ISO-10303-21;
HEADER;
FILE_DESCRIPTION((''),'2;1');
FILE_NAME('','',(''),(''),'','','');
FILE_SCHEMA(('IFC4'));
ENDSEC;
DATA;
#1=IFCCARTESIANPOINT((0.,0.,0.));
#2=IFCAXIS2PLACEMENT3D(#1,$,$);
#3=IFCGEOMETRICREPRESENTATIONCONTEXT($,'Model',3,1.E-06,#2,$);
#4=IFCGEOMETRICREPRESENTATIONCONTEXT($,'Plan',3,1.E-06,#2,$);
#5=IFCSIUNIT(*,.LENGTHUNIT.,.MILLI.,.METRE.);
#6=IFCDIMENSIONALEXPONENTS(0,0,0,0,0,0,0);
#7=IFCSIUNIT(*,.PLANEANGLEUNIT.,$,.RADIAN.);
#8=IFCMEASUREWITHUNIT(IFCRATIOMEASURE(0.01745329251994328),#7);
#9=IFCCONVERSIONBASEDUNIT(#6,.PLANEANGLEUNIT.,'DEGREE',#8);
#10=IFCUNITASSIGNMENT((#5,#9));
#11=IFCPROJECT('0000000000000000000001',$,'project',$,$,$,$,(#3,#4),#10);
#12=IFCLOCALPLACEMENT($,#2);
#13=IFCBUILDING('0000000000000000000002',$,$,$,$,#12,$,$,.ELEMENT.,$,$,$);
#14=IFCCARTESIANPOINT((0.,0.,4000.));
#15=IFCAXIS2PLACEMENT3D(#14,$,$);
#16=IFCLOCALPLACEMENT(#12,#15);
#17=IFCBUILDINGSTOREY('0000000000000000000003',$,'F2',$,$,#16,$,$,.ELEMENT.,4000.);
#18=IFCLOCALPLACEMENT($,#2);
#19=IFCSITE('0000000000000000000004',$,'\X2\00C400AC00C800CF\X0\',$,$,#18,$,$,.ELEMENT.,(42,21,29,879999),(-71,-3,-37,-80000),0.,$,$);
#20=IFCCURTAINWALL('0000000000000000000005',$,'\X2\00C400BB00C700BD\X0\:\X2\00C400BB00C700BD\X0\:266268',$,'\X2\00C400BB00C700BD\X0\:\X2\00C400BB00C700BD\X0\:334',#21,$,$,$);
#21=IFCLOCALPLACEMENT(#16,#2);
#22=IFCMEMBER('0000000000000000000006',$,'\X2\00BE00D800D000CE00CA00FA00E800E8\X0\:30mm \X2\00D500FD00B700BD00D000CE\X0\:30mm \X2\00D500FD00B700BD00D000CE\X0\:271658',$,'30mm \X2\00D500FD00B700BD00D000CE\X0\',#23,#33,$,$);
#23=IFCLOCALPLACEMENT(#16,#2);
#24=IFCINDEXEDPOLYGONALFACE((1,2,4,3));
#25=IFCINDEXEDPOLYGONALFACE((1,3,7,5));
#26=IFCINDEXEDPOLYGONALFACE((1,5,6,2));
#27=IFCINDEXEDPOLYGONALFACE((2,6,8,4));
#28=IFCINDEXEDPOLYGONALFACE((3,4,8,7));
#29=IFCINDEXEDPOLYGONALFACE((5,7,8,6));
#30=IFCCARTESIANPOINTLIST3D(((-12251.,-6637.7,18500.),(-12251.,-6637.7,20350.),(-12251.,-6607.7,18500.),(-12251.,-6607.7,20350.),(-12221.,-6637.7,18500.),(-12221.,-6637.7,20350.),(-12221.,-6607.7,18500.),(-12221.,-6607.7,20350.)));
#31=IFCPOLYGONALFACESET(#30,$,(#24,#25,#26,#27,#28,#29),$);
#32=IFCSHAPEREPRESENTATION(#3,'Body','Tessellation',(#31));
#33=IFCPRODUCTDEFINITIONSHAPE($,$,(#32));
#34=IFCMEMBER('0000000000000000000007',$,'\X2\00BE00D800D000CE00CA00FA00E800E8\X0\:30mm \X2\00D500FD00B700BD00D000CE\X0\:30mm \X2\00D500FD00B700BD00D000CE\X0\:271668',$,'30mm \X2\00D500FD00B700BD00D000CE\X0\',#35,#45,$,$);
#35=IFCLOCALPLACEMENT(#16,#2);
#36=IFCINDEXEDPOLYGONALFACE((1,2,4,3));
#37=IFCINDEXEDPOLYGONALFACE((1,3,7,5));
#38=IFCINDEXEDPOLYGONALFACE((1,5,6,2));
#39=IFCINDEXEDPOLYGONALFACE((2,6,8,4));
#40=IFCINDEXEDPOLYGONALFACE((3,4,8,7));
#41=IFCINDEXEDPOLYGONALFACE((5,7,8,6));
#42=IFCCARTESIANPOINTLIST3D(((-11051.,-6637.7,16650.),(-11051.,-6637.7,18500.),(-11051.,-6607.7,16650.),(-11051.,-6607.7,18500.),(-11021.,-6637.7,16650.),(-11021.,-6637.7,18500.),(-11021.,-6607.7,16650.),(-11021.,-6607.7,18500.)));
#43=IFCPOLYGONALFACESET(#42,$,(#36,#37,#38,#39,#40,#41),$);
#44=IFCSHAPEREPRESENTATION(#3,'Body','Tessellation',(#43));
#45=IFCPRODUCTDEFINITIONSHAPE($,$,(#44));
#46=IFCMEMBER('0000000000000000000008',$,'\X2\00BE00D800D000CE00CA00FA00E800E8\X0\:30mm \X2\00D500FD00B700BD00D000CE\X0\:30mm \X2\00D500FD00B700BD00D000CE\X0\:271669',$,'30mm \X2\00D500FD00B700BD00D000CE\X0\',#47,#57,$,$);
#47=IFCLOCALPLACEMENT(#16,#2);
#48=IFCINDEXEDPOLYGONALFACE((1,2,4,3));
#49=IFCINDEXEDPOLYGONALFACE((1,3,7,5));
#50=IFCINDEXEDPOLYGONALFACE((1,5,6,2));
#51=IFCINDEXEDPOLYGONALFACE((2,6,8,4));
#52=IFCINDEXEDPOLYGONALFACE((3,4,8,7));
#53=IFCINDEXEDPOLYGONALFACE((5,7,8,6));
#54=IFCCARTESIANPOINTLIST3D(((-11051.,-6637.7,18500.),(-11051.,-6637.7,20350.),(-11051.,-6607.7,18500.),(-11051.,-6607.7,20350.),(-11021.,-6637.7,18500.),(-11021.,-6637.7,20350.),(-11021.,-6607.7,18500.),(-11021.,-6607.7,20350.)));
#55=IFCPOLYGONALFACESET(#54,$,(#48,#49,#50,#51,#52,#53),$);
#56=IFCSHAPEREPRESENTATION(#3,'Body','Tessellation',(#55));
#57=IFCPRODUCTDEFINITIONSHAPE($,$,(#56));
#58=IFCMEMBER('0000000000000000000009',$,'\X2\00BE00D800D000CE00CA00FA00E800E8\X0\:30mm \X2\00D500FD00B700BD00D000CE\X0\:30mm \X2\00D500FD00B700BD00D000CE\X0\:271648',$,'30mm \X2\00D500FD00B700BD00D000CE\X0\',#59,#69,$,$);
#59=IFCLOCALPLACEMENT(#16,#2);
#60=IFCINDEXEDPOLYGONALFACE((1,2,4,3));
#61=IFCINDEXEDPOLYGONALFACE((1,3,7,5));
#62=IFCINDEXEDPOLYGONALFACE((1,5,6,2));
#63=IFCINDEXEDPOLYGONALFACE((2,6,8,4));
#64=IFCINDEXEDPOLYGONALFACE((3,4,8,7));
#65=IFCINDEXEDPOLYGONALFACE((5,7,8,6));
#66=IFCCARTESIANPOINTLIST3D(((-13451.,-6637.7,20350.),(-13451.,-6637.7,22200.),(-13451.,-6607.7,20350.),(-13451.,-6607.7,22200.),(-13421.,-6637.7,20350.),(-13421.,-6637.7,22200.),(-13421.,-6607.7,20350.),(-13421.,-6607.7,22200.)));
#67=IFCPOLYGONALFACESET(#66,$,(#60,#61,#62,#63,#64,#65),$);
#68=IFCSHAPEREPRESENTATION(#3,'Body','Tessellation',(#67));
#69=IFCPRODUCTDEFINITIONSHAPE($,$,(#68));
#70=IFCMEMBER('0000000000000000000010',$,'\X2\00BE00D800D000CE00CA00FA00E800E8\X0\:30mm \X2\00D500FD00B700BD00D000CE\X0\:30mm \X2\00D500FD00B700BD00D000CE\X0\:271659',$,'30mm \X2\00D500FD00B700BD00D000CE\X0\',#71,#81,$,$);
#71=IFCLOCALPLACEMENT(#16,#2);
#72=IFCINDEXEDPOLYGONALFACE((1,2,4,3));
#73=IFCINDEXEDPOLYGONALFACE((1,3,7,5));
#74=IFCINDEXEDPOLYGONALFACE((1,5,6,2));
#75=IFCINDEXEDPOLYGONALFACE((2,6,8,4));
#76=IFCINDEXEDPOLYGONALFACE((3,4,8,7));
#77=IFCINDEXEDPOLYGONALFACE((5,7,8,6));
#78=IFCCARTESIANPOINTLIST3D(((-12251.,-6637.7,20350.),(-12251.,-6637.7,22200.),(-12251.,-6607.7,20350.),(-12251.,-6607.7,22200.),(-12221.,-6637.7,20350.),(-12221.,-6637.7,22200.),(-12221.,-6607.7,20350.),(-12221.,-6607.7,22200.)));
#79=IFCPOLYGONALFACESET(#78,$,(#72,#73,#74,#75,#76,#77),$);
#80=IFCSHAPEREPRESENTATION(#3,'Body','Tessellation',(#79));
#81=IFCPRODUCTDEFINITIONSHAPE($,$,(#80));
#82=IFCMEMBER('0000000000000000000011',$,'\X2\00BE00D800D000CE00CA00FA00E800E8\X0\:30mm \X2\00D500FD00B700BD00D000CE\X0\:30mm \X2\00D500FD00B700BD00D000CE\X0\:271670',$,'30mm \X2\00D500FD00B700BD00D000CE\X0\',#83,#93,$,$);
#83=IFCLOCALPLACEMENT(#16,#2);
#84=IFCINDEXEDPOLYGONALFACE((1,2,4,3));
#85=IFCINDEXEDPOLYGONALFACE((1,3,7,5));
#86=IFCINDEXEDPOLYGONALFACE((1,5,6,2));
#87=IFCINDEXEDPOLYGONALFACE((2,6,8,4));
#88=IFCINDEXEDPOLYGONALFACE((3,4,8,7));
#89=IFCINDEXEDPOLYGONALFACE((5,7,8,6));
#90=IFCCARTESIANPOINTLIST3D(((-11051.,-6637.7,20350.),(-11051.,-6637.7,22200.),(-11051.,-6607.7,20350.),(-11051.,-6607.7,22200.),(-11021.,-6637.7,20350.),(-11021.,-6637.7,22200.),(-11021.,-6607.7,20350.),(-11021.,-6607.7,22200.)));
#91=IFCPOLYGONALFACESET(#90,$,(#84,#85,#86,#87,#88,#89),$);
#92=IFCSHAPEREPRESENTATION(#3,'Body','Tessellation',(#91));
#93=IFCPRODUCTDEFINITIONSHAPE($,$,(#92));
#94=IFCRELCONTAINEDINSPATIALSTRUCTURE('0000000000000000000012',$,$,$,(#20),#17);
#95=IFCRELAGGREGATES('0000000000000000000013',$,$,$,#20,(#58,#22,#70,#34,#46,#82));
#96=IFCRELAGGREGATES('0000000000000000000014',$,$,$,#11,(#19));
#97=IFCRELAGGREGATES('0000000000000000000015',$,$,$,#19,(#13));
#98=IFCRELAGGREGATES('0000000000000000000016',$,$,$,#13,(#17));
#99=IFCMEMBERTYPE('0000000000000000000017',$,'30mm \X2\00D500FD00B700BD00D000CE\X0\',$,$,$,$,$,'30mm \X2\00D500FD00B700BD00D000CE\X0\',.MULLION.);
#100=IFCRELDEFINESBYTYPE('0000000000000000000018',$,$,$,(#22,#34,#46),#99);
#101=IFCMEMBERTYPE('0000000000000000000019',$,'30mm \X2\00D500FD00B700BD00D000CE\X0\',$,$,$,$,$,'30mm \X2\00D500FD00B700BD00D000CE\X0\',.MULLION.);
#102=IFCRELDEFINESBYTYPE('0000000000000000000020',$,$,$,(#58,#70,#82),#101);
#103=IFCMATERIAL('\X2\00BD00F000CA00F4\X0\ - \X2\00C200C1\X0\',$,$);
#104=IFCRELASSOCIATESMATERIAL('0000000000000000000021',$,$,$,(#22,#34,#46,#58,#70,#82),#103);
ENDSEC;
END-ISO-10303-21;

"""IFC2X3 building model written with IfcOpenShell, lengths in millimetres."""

from ifc_helpers import new_model, entity, si_unit, converted_unit, frame, origin, origin_2d_with_axis, place, context, project, spatial, rectangle, extrude, source, transform, mapped, material, type_object, type_shapes, element, aggregate, save


model = new_model("IFC2X3")

# Units and contexts
model_context = context("Model", 3, precision=1e-06, world=origin())
plan_context = context("Plan", 3, precision=1e-06, world=origin())
ifc_project = project(units=[si_unit("LENGTHUNIT", "METRE", prefix="MILLI"), converted_unit("PLANEANGLEUNIT", "DEGREE", entity("IfcRatioMeasure", 0.01745329251994328), si_unit("PLANEANGLEUNIT", "RADIAN"), dimensions=[0, 0, 0, 0, 0, 0, 0])], contexts=[model_context, plan_context])

# Site, building, storey
site_placement = place(None, origin())
site = spatial("IfcSite", under=ifc_project, at=site_placement, Name="Ä¬ÈÏ", CompositionType="ELEMENT", RefLatitude=(42, 21, 29, 879999), RefLongitude=(-71, -3, -37, -80000), RefElevation=0.0)
building_placement = place(None, origin())
building = spatial("IfcBuilding", under=site, at=building_placement, CompositionType="ELEMENT")
storey_placement = place(building_placement, frame((0.0, 0.0, 4000.0)))
storey = spatial("IfcBuildingStorey", under=building, at=storey_placement, Name="F2", CompositionType="ELEMENT", Elevation=4000.0)

# Curtain wall, members
curtain_wall_placement = place(storey_placement, origin())
curtain_wall = element("IfcCurtainWall", 1, at=curtain_wall_placement, inside=storey, Name="Ä»Ç½:Ä»Ç½:266268", ObjectType="Ä»Ç½:Ä»Ç½:334")
ifc_material_1 = material(Name="½ðÊô - ÂÁ")
placement_1 = place(building_placement, frame((0.0, 0.0, 18800.0)))
placement_2 = place(building_placement, frame((0.0, 0.0, 22500.0)))
member_type_1 = type_object("IfcMemberType", Name="30mm Õý·½ÐÎ", ElementType="30mm Õý·½ÐÎ", PredefinedType="MULLION")
shared_shape_1 = source(origin(), model_context, "Body", "SweptSolid", [
    extrude(rectangle(XDim=30.0, YDim=30.0, at=origin_2d_with_axis()), frame((0.0, 0.0, -1850.0), z_axis=(0.0, 0.0, 1.0), x_axis=(-1.0, 0.0, 0.0)), (0.0, 0.0, 1.0), 1850.0),
])
type_shapes(member_type_1, [shared_shape_1])
member_1_placement = place(placement_2, frame((-12236.0, -6622.7, 0.0), z_axis=(0.0, 0.0, -1.0), x_axis=(1.0, 0.0, 0.0)))
member_1 = element("IfcMember", 2, at=member_1_placement, type_object=member_type_1, material=ifc_material_1, Name="¾ØÐÎÊúèè:30mm Õý·½ÐÎ:30mm Õý·½ÐÎ:271658", ObjectType="30mm Õý·½ÐÎ", context=model_context, shape_type="MappedRepresentation", body=[
    mapped(shared_shape_1, transform((0.0, 0.0, 0.0), scale=1.0)),
])
member_2_placement = place(placement_1, frame((-11036.0, -6622.7, 1850.0), z_axis=(0.0, 0.0, -1.0), x_axis=(1.0, 0.0, 0.0)))
member_2 = element("IfcMember", 3, at=member_2_placement, type_object=member_type_1, material=ifc_material_1, Name="¾ØÐÎÊúèè:30mm Õý·½ÐÎ:30mm Õý·½ÐÎ:271668", ObjectType="30mm Õý·½ÐÎ", context=model_context, shape_type="MappedRepresentation", body=[
    mapped(shared_shape_1, transform((0.0, 0.0, 0.0), scale=1.0)),
])
member_3_placement = place(placement_2, frame((-11036.0, -6622.7, 0.0), z_axis=(0.0, 0.0, -1.0), x_axis=(1.0, 0.0, 0.0)))
member_3 = element("IfcMember", 4, at=member_3_placement, type_object=member_type_1, material=ifc_material_1, Name="¾ØÐÎÊúèè:30mm Õý·½ÐÎ:30mm Õý·½ÐÎ:271669", ObjectType="30mm Õý·½ÐÎ", context=model_context, shape_type="MappedRepresentation", body=[
    mapped(shared_shape_1, transform((0.0, 0.0, 0.0), scale=1.0)),
])
member_type_2 = type_object("IfcMemberType", Name="30mm Õý·½ÐÎ", ElementType="30mm Õý·½ÐÎ", PredefinedType="MULLION")
shared_shape_2 = source(origin(), model_context, "Body", "SweptSolid", [
    extrude(rectangle(XDim=30.0, YDim=30.0, at=origin_2d_with_axis()), frame((0.0, 0.0, -1850.0), z_axis=(0.0, 0.0, 1.0), x_axis=(-1.0, 0.0, 0.0)), (0.0, 0.0, 1.0), 1850.0),
])
type_shapes(member_type_2, [shared_shape_2])
member_4_placement = place(placement_2, frame((-13436.0, -6622.7, 1850.0), z_axis=(0.0, 0.0, -1.0), x_axis=(1.0, 0.0, 0.0)))
member_4 = element("IfcMember", 5, at=member_4_placement, type_object=member_type_2, material=ifc_material_1, Name="¾ØÐÎÊúèè:30mm Õý·½ÐÎ:30mm Õý·½ÐÎ:271648", ObjectType="30mm Õý·½ÐÎ", context=model_context, shape_type="MappedRepresentation", body=[
    mapped(shared_shape_2, transform((0.0, 0.0, 0.0), scale=1.0)),
])
member_5_placement = place(placement_2, frame((-12236.0, -6622.7, 1850.0), z_axis=(0.0, 0.0, -1.0), x_axis=(1.0, 0.0, 0.0)))
member_5 = element("IfcMember", 6, at=member_5_placement, type_object=member_type_2, material=ifc_material_1, Name="¾ØÐÎÊúèè:30mm Õý·½ÐÎ:30mm Õý·½ÐÎ:271659", ObjectType="30mm Õý·½ÐÎ", context=model_context, shape_type="MappedRepresentation", body=[
    mapped(shared_shape_2, transform((0.0, 0.0, 0.0), scale=1.0)),
])
member_6_placement = place(placement_2, frame((-11036.0, -6622.7, 1850.0), z_axis=(0.0, 0.0, -1.0), x_axis=(1.0, 0.0, 0.0)))
member_6 = element("IfcMember", 7, at=member_6_placement, type_object=member_type_2, material=ifc_material_1, Name="¾ØÐÎÊúèè:30mm Õý·½ÐÎ:30mm Õý·½ÐÎ:271670", ObjectType="30mm Õý·½ÐÎ", context=model_context, shape_type="MappedRepresentation", body=[
    mapped(shared_shape_2, transform((0.0, 0.0, 0.0), scale=1.0)),
])
aggregate(curtain_wall, [member_4, member_1, member_5, member_2, member_3, member_6])

save(model, "model.ifc")
